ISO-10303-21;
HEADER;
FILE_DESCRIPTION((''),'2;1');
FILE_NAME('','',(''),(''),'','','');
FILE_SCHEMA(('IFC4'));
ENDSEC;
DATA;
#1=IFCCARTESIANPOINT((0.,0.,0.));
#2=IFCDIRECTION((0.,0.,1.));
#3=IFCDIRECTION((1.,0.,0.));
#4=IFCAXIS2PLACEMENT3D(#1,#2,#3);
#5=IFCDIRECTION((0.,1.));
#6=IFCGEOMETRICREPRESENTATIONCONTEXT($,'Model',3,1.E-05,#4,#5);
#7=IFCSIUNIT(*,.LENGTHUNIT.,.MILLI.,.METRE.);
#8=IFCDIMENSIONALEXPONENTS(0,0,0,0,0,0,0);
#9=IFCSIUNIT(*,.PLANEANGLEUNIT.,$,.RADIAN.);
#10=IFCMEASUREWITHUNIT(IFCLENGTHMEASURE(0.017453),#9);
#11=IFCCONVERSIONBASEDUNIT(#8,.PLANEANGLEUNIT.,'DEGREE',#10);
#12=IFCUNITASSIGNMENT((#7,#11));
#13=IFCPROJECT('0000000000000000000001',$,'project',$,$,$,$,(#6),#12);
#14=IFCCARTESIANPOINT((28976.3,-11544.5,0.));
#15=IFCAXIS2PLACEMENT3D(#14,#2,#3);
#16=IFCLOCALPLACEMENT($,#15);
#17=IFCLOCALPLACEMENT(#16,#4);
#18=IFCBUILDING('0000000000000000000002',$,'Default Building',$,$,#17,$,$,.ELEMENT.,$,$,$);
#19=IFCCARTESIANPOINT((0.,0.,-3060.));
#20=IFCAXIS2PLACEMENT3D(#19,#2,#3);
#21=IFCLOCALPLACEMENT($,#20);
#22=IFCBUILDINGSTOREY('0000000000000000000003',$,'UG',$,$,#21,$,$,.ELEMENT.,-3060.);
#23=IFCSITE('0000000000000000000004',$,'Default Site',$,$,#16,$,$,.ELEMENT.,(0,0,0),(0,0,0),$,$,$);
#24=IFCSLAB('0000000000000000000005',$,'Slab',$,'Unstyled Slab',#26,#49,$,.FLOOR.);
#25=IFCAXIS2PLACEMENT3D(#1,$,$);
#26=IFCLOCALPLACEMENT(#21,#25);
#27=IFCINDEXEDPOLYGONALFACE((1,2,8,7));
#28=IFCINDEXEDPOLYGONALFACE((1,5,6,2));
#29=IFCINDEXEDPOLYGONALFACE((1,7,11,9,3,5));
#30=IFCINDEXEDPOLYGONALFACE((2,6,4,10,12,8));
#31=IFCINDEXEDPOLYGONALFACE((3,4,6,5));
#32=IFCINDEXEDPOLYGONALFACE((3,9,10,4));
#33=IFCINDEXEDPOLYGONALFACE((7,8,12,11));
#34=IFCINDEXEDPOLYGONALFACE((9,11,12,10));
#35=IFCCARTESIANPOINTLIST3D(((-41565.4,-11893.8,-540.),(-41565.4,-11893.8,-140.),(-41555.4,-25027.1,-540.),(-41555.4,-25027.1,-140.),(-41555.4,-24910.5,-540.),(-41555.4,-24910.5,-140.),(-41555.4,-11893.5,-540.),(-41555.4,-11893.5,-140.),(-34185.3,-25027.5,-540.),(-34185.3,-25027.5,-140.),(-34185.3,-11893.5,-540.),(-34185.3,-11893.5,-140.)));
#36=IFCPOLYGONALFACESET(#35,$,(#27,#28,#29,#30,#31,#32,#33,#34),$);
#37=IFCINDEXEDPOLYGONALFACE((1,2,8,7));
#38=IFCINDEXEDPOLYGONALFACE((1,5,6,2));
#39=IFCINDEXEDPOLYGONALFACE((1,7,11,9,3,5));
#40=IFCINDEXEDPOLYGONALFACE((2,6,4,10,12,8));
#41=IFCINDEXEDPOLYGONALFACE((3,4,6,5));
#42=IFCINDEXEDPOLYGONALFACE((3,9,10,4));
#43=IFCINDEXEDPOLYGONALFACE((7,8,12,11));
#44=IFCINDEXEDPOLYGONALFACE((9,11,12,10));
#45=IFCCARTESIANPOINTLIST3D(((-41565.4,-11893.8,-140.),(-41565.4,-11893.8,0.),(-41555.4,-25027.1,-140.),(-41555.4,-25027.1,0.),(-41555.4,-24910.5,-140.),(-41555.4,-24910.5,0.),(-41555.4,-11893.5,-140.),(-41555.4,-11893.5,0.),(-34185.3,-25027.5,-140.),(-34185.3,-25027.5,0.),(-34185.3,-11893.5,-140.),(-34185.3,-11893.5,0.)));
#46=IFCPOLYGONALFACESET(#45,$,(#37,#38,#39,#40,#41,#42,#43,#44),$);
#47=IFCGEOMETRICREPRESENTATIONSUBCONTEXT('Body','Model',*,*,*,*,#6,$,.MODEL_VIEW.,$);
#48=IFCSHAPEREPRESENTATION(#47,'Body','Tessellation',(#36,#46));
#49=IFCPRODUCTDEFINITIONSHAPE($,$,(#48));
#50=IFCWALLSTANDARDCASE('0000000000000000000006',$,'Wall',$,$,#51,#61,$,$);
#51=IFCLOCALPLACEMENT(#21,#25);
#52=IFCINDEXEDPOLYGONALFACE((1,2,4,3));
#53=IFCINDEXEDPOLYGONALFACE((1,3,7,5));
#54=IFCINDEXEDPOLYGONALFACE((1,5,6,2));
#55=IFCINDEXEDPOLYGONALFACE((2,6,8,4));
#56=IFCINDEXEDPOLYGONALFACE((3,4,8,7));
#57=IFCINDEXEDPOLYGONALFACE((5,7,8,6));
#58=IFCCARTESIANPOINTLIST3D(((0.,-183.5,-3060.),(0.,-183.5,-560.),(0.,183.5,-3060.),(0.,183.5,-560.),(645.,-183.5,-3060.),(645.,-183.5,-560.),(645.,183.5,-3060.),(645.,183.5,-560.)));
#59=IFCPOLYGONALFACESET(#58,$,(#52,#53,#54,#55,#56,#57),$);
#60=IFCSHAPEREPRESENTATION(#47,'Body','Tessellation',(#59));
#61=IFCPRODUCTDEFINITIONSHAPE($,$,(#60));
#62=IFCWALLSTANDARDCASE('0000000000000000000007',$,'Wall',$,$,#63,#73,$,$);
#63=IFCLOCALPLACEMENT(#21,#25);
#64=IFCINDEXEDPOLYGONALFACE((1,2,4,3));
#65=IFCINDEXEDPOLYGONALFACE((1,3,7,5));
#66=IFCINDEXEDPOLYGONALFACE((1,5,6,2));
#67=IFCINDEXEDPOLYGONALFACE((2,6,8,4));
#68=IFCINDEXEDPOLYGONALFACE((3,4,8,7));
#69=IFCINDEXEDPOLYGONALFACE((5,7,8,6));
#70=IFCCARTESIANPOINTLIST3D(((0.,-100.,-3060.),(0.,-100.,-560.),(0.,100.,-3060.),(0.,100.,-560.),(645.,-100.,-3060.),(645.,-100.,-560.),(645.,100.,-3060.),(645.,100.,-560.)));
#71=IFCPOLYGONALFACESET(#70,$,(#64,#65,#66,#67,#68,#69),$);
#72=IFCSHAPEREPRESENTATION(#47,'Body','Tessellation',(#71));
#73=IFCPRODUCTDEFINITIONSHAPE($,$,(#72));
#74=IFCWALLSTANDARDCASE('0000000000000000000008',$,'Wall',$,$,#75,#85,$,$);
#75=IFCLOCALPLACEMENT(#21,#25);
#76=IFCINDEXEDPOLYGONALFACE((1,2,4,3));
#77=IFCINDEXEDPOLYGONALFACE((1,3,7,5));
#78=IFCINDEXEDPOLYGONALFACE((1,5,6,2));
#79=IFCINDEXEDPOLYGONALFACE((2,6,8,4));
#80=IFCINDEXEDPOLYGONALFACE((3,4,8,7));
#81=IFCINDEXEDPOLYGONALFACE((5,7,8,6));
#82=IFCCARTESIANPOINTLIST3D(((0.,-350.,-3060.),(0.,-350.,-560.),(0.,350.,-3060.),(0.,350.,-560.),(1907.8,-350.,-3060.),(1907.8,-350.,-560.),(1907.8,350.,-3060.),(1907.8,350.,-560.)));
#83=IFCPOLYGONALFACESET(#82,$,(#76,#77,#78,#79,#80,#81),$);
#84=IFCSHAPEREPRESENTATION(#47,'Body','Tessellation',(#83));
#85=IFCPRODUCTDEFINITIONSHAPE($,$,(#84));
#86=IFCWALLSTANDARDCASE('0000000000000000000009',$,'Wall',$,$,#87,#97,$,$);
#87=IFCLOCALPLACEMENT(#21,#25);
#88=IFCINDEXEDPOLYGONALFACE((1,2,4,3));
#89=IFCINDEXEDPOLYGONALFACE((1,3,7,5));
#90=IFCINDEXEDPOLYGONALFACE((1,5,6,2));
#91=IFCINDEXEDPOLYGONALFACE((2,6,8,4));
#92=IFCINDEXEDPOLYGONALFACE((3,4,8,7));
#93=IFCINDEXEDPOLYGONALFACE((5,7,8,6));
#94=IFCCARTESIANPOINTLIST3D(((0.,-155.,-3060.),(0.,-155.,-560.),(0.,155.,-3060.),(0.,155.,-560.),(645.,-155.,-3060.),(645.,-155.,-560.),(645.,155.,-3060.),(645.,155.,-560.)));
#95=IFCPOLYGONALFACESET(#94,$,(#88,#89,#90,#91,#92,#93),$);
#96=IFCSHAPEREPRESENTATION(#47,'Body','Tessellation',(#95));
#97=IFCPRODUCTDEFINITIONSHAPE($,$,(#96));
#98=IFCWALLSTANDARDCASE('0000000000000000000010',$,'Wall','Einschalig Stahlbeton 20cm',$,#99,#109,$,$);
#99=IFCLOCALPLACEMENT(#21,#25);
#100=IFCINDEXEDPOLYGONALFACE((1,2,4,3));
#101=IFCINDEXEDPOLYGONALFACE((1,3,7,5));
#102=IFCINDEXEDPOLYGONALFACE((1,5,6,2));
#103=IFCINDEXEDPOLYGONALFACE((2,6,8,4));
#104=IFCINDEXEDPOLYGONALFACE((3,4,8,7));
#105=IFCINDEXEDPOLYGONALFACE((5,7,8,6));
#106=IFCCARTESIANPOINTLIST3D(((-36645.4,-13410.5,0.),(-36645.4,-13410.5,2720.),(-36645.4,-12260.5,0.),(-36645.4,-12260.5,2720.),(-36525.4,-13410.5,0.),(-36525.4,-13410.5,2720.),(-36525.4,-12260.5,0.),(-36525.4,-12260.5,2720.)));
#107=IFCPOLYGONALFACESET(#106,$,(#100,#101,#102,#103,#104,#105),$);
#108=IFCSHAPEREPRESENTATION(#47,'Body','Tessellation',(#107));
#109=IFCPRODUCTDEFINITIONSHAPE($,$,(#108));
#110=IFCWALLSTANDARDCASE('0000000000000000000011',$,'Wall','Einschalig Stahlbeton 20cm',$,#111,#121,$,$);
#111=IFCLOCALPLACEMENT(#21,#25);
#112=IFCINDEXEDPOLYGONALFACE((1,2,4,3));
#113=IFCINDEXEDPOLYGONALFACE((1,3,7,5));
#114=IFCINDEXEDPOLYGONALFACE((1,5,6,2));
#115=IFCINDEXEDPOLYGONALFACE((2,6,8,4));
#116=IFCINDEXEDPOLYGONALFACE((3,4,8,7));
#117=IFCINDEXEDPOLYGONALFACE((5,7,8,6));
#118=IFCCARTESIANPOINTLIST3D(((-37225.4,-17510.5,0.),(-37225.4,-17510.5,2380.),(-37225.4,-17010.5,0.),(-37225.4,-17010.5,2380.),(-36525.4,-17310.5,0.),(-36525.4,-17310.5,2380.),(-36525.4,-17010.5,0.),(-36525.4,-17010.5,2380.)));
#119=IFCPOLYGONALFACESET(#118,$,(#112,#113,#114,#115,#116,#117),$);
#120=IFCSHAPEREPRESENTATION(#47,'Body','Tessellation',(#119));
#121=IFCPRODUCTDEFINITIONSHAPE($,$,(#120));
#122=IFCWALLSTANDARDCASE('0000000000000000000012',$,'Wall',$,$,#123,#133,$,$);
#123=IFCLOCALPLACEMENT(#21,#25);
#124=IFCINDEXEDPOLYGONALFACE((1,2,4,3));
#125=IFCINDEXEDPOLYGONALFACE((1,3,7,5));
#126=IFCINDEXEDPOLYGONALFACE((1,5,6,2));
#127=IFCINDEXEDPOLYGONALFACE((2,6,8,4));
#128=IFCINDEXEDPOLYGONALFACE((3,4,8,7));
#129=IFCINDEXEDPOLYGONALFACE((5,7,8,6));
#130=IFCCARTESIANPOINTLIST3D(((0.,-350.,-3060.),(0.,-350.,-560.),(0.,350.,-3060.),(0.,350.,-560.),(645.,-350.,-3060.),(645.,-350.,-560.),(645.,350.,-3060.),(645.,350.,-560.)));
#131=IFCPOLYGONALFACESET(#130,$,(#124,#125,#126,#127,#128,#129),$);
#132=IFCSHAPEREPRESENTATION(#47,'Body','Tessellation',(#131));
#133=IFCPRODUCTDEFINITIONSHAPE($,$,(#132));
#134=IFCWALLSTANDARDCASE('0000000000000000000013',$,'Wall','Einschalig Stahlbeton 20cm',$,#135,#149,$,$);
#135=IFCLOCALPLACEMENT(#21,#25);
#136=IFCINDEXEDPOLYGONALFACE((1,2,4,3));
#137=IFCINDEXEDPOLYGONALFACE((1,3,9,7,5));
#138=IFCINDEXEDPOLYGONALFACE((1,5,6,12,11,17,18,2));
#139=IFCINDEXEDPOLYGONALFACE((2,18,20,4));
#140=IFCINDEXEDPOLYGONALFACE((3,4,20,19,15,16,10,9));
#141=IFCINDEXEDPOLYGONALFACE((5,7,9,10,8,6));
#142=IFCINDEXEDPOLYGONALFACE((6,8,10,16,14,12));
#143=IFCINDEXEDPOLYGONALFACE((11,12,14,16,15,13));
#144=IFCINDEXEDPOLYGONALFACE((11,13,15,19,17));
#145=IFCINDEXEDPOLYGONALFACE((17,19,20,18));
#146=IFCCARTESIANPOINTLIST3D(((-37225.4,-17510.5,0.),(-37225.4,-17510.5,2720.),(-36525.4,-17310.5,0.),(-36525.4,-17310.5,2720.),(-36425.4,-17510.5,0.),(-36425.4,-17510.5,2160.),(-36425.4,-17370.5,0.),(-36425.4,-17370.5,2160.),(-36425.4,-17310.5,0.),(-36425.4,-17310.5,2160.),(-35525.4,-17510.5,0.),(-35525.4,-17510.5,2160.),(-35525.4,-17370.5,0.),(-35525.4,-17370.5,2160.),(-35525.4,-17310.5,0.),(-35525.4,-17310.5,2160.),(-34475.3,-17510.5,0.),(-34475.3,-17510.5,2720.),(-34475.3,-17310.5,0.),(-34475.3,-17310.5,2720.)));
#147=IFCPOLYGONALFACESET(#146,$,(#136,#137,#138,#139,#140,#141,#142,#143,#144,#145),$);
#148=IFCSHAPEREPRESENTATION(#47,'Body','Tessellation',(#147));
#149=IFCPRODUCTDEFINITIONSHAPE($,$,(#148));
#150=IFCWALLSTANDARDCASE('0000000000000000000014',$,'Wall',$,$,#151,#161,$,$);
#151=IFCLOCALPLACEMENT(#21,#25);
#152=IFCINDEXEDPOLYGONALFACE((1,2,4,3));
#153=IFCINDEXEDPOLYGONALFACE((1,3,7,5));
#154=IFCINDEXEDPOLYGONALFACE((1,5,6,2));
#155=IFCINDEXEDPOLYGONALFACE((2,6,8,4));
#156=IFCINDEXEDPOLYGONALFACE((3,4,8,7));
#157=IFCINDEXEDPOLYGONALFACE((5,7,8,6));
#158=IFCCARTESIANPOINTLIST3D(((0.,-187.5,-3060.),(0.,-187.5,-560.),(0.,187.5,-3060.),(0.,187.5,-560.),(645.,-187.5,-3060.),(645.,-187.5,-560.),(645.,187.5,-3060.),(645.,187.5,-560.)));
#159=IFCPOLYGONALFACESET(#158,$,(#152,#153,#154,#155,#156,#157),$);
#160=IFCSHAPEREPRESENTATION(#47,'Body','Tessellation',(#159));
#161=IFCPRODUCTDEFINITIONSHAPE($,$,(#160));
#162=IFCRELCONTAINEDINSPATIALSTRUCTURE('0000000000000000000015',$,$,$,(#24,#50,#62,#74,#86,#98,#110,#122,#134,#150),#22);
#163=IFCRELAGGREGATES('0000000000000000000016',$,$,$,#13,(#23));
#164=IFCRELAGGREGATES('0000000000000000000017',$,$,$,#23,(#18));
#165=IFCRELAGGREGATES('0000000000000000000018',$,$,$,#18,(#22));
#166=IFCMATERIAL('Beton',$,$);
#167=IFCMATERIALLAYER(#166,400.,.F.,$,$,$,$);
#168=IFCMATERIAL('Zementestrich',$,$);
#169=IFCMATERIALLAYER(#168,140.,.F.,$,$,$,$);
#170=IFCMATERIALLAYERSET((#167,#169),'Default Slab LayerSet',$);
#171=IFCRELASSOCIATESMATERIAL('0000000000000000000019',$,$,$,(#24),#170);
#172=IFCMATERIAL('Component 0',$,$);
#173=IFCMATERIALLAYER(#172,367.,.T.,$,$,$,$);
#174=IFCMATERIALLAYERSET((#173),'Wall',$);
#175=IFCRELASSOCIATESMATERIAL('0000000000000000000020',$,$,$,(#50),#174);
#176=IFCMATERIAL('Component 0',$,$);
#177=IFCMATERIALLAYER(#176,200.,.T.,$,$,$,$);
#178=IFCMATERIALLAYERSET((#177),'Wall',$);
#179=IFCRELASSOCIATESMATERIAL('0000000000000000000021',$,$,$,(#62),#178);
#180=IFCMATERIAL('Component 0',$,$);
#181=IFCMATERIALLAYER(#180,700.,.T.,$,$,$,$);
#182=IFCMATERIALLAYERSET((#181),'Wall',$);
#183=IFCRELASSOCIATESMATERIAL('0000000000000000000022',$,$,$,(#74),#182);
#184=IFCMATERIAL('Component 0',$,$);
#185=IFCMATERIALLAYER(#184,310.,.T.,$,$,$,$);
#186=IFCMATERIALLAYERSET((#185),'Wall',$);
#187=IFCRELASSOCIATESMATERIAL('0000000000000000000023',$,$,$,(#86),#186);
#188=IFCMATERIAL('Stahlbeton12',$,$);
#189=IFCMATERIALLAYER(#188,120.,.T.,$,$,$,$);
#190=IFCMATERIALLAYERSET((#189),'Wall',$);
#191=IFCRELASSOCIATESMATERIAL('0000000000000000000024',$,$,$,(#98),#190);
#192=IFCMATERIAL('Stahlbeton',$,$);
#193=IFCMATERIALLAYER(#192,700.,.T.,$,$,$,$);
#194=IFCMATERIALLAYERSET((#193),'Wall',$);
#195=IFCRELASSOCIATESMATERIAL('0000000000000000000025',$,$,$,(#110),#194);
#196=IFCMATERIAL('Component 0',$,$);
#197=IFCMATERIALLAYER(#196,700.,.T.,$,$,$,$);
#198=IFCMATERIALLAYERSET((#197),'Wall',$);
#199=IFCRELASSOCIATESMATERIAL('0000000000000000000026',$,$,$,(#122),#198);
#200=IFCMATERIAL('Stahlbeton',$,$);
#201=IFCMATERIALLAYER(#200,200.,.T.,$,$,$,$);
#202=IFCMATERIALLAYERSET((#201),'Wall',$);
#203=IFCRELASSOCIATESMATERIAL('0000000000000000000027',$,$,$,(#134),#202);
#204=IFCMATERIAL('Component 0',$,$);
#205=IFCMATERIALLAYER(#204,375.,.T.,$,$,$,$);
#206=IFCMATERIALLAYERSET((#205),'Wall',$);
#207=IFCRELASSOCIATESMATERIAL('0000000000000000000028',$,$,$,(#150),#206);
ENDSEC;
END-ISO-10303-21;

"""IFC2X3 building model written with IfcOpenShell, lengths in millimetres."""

from ifc_helpers import new_model, entity, si_unit, converted_unit, direction, frame, origin_with_axes, place, context, subcontext, project, spatial, polyline, outline, extrude, material, layer, layer_set, layer_usage, element, save


model = new_model("IFC2X3")

# Units and contexts
model_context = context("Model", 3, precision=1e-05, world=origin_with_axes(), true_north=direction((0.0, 1.0)))
body_context = subcontext(model_context, "Body", "Model", "MODEL_VIEW")
ifc_project = project(units=[si_unit("LENGTHUNIT", "METRE", prefix="MILLI"), converted_unit("PLANEANGLEUNIT", "DEGREE", entity("IfcLengthMeasure", 0.017453), si_unit("PLANEANGLEUNIT", "RADIAN"), dimensions=[0, 0, 0, 0, 0, 0, 0])], contexts=[model_context])

# Site, building, storey
site_placement = place(None, frame((28976.3, -11544.5, 0.0), z_axis=(0.0, 0.0, 1.0), x_axis=(1.0, 0.0, 0.0)))
site = spatial("IfcSite", under=ifc_project, at=site_placement, Name="Default Site", CompositionType="ELEMENT", RefLatitude=(0, 0, 0), RefLongitude=(0, 0, 0))
building_placement = place(site_placement, origin_with_axes())
building = spatial("IfcBuilding", under=site, at=building_placement, Name="Default Building", CompositionType="ELEMENT")
storey_placement = place(None, frame((0.0, 0.0, -3060.0), z_axis=(0.0, 0.0, 1.0), x_axis=(1.0, 0.0, 0.0)))
storey = spatial("IfcBuildingStorey", under=building, at=storey_placement, Name="UG", CompositionType="ELEMENT", Elevation=-3060.0)

# Slab
ifc_material_1 = material(Name="Beton")
ifc_layer_1 = layer(ifc_material_1, 400.0, ventilated=False)
ifc_material_2 = material(Name="Zementestrich")
ifc_layer_2 = layer(ifc_material_2, 140.0, ventilated=False)
ifc_layer_set_1 = layer_set([ifc_layer_1, ifc_layer_2], Name="Default Slab LayerSet")
ifc_layer_usage_1 = layer_usage(ifc_layer_set_1, "AXIS3", "NEGATIVE", 0.0)
slab_placement = place(storey_placement, frame((0.0, 0.0, 3060.0), z_axis=(0.0, 0.0, 1.0), x_axis=(1.0, 0.0, 0.0)))
element("IfcSlab", 1, at=slab_placement, inside=storey, material=ifc_layer_usage_1, Name="Slab", ObjectType="Unstyled Slab", PredefinedType="FLOOR", context=body_context, shape_type="SweptSolid", body=[
    extrude(outline(polyline([(-10.0, 0.4), (0.0, 13017.0), (0.0, 13133.7), (7370.0, 13134.0), (7370.0, 0.0), (0.0, 0.0), (-10.0, 0.4)])), frame((-41555.4, -11893.5, -3600.0), z_axis=(0.0, 0.0, -1.0), x_axis=(1.0, 0.0, 0.0)), (0.0, 0.0, -1.0), 400.0),
    extrude(outline(polyline([(-10.0, 0.4), (0.0, 13017.0), (0.0, 13133.7), (7370.0, 13134.0), (7370.0, 0.0), (0.0, 0.0), (-10.0, 0.4)])), frame((-41555.4, -11893.5, -3200.0), z_axis=(0.0, 0.0, -1.0), x_axis=(1.0, 0.0, 0.0)), (0.0, 0.0, -1.0), 140.0),
])

# Walls
ifc_material_3 = material(Name="Component 0")
ifc_layer_3 = layer(ifc_material_3, 367.0, ventilated=True)
ifc_layer_set_2 = layer_set([ifc_layer_3], Name="Wall")
ifc_layer_usage_2 = layer_usage(ifc_layer_set_2, "AXIS2", "POSITIVE", -183.5)
wall_1_placement = place(storey_placement, frame((0.0, 0.0, -3060.0), z_axis=(0.0, 0.0, 1.0), x_axis=(1.0, 0.0, 0.0)))
element("IfcWallStandardCase", 2, at=wall_1_placement, inside=storey, material=ifc_layer_usage_2, Name="Wall", context=body_context, shape_type="SweptSolid", body=[
    extrude(outline(polyline([(0.0, -183.5), (0.0, 183.5), (645.0, 183.5), (645.0, -183.5), (0.0, -183.5)])), origin_with_axes(), (0.0, 0.0, 1.0), 2500.0),
])
ifc_material_4 = material(Name="Component 0")
ifc_layer_4 = layer(ifc_material_4, 200.0, ventilated=True)
ifc_layer_set_3 = layer_set([ifc_layer_4], Name="Wall")
ifc_layer_usage_3 = layer_usage(ifc_layer_set_3, "AXIS2", "POSITIVE", -100.0)
wall_2_placement = place(storey_placement, frame((0.0, 0.0, -3060.0), z_axis=(0.0, 0.0, 1.0), x_axis=(1.0, 0.0, 0.0)))
element("IfcWallStandardCase", 3, at=wall_2_placement, inside=storey, material=ifc_layer_usage_3, Name="Wall", context=body_context, shape_type="SweptSolid", body=[
    extrude(outline(polyline([(0.0, -100.0), (0.0, 100.0), (645.0, 100.0), (645.0, -100.0), (0.0, -100.0)])), origin_with_axes(), (0.0, 0.0, 1.0), 2500.0),
])
ifc_material_5 = material(Name="Component 0")
ifc_layer_5 = layer(ifc_material_5, 700.0, ventilated=True)
ifc_layer_set_4 = layer_set([ifc_layer_5], Name="Wall")
ifc_layer_usage_4 = layer_usage(ifc_layer_set_4, "AXIS2", "POSITIVE", -350.0)
wall_3_placement = place(storey_placement, frame((0.0, 0.0, -3060.0), z_axis=(0.0, 0.0, 1.0), x_axis=(1.0, 0.0, 0.0)))
element("IfcWallStandardCase", 4, at=wall_3_placement, inside=storey, material=ifc_layer_usage_4, Name="Wall", context=body_context, shape_type="SweptSolid", body=[
    extrude(outline(polyline([(0.0, -350.0), (0.0, 350.0), (1907.8, 350.0), (1907.8, -350.0), (0.0, -350.0)])), origin_with_axes(), (0.0, 0.0, 1.0), 2500.0),
])
ifc_material_6 = material(Name="Component 0")
ifc_layer_6 = layer(ifc_material_6, 310.0, ventilated=True)
ifc_layer_set_5 = layer_set([ifc_layer_6], Name="Wall")
ifc_layer_usage_5 = layer_usage(ifc_layer_set_5, "AXIS2", "POSITIVE", -155.0)
wall_4_placement = place(storey_placement, frame((0.0, 0.0, -3060.0), z_axis=(0.0, 0.0, 1.0), x_axis=(1.0, 0.0, 0.0)))
element("IfcWallStandardCase", 5, at=wall_4_placement, inside=storey, material=ifc_layer_usage_5, Name="Wall", context=body_context, shape_type="SweptSolid", body=[
    extrude(outline(polyline([(0.0, -155.0), (0.0, 155.0), (645.0, 155.0), (645.0, -155.0), (0.0, -155.0)])), origin_with_axes(), (0.0, 0.0, 1.0), 2500.0),
])
ifc_material_7 = material(Name="Stahlbeton12")
ifc_layer_7 = layer(ifc_material_7, 120.0, ventilated=True)
ifc_layer_set_6 = layer_set([ifc_layer_7], Name="Wall")
ifc_layer_usage_6 = layer_usage(ifc_layer_set_6, "AXIS2", "POSITIVE", -60.0)
wall_5_placement = place(storey_placement, frame((-36585.4, -13410.5, 0.0), z_axis=(0.0, 0.0, 1.0), x_axis=(0.0, 1.0, 0.0)))
element("IfcWallStandardCase", 6, at=wall_5_placement, inside=storey, material=ifc_layer_usage_6, Name="Wall", Description="Einschalig Stahlbeton 20cm", context=body_context, shape_type="SweptSolid", body=[
    extrude(outline(polyline([(0.0, -60.0), (0.0, 60.0), (1150.0, 60.0), (1150.0, -60.0), (0.0, -60.0)])), origin_with_axes(), (0.0, 0.0, 1.0), 2720.0),
])
ifc_material_8 = material(Name="Stahlbeton")
ifc_layer_8 = layer(ifc_material_8, 700.0, ventilated=True)
ifc_layer_set_7 = layer_set([ifc_layer_8], Name="Wall")
ifc_layer_usage_7 = layer_usage(ifc_layer_set_7, "AXIS2", "POSITIVE", -350.0)
wall_6_placement = place(storey_placement, frame((-36875.4, -17410.5, 0.0), z_axis=(0.0, 0.0, 1.0), x_axis=(0.0, 1.0, 0.0)))
element("IfcWallStandardCase", 7, at=wall_6_placement, inside=storey, material=ifc_layer_usage_7, Name="Wall", Description="Einschalig Stahlbeton 20cm", context=body_context, shape_type="SweptSolid", body=[
    extrude(outline(polyline([(400.0, 350.0), (-100.0, 350.0), (100.0, -350.0), (400.0, -350.0), (400.0, 350.0)])), origin_with_axes(), (0.0, 0.0, 1.0), 2380.0),
])
ifc_material_9 = material(Name="Component 0")
ifc_layer_9 = layer(ifc_material_9, 700.0, ventilated=True)
ifc_layer_set_8 = layer_set([ifc_layer_9], Name="Wall")
ifc_layer_usage_8 = layer_usage(ifc_layer_set_8, "AXIS2", "POSITIVE", -350.0)
wall_7_placement = place(storey_placement, frame((0.0, 0.0, -3060.0), z_axis=(0.0, 0.0, 1.0), x_axis=(1.0, 0.0, 0.0)))
element("IfcWallStandardCase", 8, at=wall_7_placement, inside=storey, material=ifc_layer_usage_8, Name="Wall", context=body_context, shape_type="SweptSolid", body=[
    extrude(outline(polyline([(0.0, -350.0), (0.0, 350.0), (645.0, 350.0), (645.0, -350.0), (0.0, -350.0)])), origin_with_axes(), (0.0, 0.0, 1.0), 2500.0),
])

# Wall, opening
ifc_material_10 = material(Name="Stahlbeton")
ifc_layer_10 = layer(ifc_material_10, 200.0, ventilated=True)
ifc_layer_set_9 = layer_set([ifc_layer_10], Name="Wall")
ifc_layer_usage_9 = layer_usage(ifc_layer_set_9, "AXIS2", "POSITIVE", -100.0)
wall_8_placement = place(storey_placement, frame((-36875.4, -17410.5, 0.0), z_axis=(0.0, 0.0, 1.0), x_axis=(1.0, 0.0, 0.0)))
wall_8 = element("IfcWallStandardCase", 9, at=wall_8_placement, inside=storey, material=ifc_layer_usage_9, Name="Wall", Description="Einschalig Stahlbeton 20cm", context=body_context, shape_type="SweptSolid", body=[
    extrude(outline(polyline([(2400.0, -100.0), (2400.0, 100.0), (350.0, 100.0), (-350.0, -100.0), (2400.0, -100.0)])), origin_with_axes(), (0.0, 0.0, 1.0), 2720.0),
])
opening_placement = place(wall_8_placement, origin_with_axes())
element("IfcOpeningElement", 10, at=opening_placement, cuts=wall_8, context=body_context, shape_type="SweptSolid", body=[
    extrude(outline(polyline([(-450.0, 0.0), (-450.0, -2160.0), (450.0, -2160.0), (450.0, 0.0), (-450.0, 0.0), (-450.0, 0.0)])), frame((900.0, 100.0, 0.0), z_axis=(0.0, -1.0, 0.0), x_axis=(-1.0, 0.0, 0.0)), (0.0, 0.0, 1.0), 60.0),
    extrude(outline(polyline([(-450.0, 0.0), (-450.0, -2160.0), (450.0, -2160.0), (450.0, 0.0), (-450.0, 0.0), (-450.0, 0.0)])), frame((900.0, 40.0, 0.0), z_axis=(0.0, -1.0, 0.0), x_axis=(-1.0, 0.0, 0.0)), (0.0, 0.0, 1.0), 140.0),
])

# Wall
ifc_material_11 = material(Name="Component 0")
ifc_layer_11 = layer(ifc_material_11, 375.0, ventilated=True)
ifc_layer_set_10 = layer_set([ifc_layer_11], Name="Wall")
ifc_layer_usage_10 = layer_usage(ifc_layer_set_10, "AXIS2", "POSITIVE", -187.5)
wall_9_placement = place(storey_placement, frame((0.0, 0.0, -3060.0), z_axis=(0.0, 0.0, 1.0), x_axis=(1.0, 0.0, 0.0)))
element("IfcWallStandardCase", 11, at=wall_9_placement, inside=storey, material=ifc_layer_usage_10, Name="Wall", context=body_context, shape_type="SweptSolid", body=[
    extrude(outline(polyline([(0.0, -187.5), (0.0, 187.5), (645.0, 187.5), (645.0, -187.5), (0.0, -187.5)])), origin_with_axes(), (0.0, 0.0, 1.0), 2500.0),
])

save(model, "model.ifc")
